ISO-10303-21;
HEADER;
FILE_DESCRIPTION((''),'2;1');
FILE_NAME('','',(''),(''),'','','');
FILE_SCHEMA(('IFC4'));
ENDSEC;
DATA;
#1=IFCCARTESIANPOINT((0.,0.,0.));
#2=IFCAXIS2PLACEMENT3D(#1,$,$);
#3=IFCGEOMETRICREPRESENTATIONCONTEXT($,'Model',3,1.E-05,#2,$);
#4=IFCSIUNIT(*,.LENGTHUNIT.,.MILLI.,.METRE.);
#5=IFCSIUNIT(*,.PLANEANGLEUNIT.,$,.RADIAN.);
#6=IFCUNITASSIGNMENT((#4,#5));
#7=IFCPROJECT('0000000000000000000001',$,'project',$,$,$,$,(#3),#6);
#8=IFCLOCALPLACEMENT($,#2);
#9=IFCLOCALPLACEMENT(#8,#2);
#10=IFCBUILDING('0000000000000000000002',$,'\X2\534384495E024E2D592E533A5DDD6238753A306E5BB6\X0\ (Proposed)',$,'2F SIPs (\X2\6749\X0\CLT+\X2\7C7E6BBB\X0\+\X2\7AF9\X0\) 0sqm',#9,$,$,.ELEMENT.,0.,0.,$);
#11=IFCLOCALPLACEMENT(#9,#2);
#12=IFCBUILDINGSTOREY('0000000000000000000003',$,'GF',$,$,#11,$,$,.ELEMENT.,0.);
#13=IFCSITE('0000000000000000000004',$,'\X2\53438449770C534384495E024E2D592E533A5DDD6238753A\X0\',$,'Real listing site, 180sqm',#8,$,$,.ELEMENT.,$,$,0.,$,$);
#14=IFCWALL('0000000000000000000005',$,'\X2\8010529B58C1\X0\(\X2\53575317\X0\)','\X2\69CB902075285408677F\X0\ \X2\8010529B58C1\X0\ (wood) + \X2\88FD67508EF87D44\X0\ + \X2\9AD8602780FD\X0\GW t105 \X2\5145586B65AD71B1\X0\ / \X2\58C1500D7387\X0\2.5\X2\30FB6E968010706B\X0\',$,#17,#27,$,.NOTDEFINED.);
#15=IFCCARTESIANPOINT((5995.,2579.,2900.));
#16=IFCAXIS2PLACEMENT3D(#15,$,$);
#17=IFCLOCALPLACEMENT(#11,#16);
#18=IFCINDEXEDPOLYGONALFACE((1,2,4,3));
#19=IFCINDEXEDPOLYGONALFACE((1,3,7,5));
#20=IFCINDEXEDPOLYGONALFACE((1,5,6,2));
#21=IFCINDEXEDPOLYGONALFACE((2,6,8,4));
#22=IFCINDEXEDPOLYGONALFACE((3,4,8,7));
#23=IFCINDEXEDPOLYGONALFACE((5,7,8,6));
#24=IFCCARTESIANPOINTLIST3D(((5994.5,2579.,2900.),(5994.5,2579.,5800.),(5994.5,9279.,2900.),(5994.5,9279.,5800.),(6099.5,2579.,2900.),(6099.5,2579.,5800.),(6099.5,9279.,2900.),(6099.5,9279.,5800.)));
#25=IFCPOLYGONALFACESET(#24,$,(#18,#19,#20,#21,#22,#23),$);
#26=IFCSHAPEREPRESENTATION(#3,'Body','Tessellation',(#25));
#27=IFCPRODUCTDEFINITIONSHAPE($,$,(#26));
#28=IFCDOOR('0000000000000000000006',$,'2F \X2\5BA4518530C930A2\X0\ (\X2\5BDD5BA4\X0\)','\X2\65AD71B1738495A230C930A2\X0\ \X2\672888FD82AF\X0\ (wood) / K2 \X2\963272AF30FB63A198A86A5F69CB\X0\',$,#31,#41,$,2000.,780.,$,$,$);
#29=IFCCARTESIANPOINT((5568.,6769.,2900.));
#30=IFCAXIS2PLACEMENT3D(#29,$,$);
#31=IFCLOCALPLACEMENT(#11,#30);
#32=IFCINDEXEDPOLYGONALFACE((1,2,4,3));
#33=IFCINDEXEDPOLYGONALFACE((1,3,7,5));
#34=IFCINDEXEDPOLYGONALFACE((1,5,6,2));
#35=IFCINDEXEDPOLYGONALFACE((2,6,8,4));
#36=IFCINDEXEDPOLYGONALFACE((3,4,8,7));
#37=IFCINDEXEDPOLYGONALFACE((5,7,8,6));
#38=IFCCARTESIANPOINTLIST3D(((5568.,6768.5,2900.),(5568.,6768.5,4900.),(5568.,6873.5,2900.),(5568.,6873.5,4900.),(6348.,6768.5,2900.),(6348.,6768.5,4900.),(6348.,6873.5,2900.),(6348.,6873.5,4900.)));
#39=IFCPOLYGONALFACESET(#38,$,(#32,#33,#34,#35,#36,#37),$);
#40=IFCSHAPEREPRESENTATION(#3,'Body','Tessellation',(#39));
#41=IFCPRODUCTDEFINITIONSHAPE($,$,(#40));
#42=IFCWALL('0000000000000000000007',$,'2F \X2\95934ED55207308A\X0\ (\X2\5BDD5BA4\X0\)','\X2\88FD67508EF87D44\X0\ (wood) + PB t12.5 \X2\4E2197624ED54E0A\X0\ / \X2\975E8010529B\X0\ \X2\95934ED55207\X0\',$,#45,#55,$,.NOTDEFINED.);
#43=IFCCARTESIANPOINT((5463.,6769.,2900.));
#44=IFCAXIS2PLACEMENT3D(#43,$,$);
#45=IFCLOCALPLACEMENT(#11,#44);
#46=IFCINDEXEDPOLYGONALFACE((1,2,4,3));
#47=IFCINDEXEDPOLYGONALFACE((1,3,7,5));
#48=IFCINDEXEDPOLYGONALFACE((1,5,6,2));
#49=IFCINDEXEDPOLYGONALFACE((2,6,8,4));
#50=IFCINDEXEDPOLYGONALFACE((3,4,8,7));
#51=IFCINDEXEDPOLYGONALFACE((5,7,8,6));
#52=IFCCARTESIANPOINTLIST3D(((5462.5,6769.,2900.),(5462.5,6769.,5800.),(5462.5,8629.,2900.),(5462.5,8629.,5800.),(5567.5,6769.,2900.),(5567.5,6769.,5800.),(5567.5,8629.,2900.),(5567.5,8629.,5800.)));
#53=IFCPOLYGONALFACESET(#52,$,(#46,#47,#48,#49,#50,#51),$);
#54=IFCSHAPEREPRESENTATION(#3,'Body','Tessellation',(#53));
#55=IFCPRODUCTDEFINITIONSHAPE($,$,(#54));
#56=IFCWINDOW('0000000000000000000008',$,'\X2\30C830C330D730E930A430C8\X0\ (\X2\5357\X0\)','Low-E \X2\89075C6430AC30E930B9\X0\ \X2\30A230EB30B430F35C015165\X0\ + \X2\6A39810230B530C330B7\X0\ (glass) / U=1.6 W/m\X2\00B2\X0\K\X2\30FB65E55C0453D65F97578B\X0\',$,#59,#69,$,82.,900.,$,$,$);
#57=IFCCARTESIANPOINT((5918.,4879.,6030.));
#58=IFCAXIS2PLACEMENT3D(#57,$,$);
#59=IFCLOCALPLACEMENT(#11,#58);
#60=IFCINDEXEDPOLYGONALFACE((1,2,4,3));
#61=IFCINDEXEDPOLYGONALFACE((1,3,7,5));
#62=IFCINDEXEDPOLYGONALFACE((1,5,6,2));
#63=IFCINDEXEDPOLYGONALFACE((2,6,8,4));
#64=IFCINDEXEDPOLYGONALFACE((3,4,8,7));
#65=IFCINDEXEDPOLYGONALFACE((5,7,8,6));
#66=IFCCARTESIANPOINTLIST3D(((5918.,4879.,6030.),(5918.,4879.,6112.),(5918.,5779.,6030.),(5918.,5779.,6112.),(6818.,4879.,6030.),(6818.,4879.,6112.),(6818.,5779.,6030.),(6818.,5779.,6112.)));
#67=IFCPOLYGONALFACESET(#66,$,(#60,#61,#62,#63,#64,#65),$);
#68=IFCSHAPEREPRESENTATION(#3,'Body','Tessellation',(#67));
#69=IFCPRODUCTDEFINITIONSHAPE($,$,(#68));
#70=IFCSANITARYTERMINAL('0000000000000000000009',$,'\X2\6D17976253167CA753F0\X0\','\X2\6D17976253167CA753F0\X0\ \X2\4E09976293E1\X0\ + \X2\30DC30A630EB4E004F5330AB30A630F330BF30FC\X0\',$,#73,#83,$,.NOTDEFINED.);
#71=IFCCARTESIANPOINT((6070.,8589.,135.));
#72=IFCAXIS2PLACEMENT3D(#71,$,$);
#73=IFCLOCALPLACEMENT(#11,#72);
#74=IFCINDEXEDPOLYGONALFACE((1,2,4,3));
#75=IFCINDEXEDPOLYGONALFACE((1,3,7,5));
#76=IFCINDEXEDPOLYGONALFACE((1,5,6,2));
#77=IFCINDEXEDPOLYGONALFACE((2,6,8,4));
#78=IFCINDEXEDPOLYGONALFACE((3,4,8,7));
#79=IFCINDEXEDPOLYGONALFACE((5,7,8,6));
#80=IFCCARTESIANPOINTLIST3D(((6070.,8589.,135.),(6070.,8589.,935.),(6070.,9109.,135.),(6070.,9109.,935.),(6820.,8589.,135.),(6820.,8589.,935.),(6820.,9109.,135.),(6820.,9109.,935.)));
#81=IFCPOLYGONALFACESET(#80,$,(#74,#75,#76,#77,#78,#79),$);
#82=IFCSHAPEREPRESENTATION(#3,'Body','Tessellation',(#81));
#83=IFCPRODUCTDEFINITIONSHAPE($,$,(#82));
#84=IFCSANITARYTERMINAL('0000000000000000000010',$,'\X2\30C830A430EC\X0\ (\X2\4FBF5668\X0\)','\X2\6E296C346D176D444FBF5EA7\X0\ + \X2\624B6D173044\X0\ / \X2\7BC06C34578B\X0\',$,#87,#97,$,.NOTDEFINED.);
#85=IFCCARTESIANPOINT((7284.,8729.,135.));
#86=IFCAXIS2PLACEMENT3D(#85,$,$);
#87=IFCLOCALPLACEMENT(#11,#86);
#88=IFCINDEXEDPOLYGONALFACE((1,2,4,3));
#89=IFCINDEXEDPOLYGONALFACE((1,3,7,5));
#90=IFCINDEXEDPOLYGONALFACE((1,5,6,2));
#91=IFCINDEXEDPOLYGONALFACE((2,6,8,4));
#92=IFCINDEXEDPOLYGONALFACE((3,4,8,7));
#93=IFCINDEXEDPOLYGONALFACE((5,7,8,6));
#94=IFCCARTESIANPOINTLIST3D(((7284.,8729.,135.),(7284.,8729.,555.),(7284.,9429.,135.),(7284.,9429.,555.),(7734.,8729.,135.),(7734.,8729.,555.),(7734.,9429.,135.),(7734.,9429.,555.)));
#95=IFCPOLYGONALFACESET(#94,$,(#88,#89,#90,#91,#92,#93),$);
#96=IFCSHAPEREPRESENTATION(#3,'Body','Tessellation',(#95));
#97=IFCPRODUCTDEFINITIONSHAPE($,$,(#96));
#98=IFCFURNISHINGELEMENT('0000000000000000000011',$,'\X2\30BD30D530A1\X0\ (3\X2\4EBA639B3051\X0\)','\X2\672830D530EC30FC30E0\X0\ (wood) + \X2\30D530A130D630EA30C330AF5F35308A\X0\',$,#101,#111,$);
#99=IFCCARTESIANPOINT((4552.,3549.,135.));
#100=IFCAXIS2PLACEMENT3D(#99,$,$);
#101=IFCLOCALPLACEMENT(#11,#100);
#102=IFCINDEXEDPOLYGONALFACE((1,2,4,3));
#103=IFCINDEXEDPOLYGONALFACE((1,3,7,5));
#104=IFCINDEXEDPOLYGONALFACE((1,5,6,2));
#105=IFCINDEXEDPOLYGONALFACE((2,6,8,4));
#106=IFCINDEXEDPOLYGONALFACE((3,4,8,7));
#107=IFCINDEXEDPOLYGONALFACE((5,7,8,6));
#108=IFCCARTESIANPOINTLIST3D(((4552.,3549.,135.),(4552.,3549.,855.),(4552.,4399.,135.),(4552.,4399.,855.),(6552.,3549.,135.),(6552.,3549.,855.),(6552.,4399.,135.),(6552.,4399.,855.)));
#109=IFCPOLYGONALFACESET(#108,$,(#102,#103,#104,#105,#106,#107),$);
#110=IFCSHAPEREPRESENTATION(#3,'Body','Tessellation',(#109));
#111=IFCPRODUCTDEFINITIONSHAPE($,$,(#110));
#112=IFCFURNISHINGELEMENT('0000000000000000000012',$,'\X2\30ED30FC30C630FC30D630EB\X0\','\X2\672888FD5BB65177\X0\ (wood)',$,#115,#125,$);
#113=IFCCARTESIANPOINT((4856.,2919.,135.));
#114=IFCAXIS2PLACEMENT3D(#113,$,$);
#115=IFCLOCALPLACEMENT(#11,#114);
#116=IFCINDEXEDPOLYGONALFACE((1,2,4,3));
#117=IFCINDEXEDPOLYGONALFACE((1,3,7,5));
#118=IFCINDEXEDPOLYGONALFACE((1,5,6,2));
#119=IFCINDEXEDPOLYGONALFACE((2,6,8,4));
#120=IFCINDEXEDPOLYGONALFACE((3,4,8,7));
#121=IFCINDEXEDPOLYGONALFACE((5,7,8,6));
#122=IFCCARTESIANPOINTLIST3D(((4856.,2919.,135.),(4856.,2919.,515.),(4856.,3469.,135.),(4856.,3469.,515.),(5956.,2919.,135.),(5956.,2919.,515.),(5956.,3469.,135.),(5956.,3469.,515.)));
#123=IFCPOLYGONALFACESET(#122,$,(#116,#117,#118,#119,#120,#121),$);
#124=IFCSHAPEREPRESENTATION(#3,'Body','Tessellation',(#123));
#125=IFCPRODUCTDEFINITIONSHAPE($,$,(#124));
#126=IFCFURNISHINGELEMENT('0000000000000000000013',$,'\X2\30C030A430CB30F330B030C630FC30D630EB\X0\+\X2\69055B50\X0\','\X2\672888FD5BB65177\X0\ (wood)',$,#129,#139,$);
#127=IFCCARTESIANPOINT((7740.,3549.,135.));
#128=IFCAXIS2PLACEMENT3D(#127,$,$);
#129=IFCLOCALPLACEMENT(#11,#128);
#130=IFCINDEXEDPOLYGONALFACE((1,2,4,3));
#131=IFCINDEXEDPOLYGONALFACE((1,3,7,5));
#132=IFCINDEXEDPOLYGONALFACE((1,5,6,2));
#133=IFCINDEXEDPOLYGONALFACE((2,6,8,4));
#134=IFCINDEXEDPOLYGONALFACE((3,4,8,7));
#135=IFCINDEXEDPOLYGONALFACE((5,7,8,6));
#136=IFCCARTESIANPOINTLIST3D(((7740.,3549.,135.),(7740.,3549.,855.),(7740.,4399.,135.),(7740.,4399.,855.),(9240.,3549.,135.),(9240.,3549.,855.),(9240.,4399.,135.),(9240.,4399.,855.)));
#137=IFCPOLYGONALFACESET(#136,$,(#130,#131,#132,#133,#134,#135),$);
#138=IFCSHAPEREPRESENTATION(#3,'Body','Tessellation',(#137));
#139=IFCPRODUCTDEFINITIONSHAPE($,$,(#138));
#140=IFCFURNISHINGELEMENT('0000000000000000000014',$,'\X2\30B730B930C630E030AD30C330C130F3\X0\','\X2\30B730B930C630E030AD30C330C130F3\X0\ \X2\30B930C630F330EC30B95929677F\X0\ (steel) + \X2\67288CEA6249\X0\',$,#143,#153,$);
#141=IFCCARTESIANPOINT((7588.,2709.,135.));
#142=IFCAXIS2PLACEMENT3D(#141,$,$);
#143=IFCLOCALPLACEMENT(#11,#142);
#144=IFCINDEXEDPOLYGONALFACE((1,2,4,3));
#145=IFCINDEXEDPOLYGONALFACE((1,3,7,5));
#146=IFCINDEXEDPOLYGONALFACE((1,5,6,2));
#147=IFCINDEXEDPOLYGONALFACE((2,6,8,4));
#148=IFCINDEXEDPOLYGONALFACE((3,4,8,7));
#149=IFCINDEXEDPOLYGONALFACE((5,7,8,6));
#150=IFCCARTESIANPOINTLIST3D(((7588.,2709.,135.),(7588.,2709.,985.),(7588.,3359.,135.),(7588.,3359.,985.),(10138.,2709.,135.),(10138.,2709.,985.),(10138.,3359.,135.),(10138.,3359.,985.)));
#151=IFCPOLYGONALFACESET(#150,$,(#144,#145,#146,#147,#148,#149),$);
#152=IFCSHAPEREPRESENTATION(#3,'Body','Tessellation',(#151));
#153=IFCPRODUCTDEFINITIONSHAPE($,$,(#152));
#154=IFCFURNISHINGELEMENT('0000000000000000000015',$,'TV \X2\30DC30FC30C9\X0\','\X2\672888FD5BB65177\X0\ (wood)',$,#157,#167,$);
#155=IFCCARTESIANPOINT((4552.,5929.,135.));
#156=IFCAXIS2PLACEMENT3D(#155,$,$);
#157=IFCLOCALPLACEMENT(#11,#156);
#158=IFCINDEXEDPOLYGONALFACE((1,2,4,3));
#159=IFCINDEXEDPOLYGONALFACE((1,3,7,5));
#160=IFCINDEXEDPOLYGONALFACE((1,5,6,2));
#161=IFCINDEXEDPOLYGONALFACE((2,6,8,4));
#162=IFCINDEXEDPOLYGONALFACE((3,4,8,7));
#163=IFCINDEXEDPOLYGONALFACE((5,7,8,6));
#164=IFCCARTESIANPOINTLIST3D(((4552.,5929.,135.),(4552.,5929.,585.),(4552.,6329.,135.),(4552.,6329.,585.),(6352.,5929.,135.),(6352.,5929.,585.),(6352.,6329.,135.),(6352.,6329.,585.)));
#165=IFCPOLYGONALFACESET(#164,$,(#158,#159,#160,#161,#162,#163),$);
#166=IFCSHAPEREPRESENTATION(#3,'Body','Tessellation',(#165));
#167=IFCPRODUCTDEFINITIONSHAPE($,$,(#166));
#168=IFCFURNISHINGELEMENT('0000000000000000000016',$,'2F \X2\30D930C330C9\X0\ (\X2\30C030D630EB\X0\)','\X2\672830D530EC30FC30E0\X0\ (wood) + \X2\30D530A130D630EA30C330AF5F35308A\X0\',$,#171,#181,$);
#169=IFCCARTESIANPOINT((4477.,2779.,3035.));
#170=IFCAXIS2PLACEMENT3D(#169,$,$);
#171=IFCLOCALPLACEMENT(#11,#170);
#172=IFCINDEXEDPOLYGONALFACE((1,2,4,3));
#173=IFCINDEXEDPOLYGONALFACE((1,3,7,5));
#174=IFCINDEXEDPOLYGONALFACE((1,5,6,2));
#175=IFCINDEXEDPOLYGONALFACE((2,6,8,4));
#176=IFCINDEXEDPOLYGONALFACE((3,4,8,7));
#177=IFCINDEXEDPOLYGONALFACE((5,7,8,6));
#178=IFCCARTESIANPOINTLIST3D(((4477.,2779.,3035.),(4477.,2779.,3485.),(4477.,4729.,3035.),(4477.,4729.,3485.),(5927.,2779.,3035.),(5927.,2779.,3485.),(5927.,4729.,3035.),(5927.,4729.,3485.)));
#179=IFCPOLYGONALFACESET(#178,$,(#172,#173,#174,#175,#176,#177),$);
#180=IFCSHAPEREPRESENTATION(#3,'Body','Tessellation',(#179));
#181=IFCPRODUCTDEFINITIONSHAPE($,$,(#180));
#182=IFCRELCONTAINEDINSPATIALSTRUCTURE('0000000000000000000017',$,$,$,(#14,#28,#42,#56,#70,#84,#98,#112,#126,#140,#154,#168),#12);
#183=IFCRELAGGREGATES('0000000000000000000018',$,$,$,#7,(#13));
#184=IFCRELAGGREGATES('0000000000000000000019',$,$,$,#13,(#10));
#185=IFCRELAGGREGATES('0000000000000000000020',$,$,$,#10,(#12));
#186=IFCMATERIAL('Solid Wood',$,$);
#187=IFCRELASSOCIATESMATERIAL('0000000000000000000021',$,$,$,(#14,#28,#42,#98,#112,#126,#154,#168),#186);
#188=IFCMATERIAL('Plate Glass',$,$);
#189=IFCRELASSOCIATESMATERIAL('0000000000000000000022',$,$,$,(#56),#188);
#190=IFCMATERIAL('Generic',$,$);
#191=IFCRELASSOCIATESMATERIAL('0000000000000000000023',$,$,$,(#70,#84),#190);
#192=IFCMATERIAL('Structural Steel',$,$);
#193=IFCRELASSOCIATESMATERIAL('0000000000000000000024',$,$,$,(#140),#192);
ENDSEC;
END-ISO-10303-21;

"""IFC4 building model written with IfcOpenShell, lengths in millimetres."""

from ifc_helpers import new_model, si_unit, frame, frame_2d, origin, place, context, project, spatial, rectangle, extrude, material, element, fill, save


model = new_model("IFC4")

# Units and contexts
model_context = context("Model", 3, precision=1e-05, world=origin())
ifc_project = project(units=[si_unit("LENGTHUNIT", "METRE", prefix="MILLI"), si_unit("PLANEANGLEUNIT", "RADIAN")], contexts=[model_context])

# Site, building, storey
site_placement = place(None, origin())
site = spatial("IfcSite", under=ifc_project, at=site_placement, Name="千葉県千葉市中央区川戸町", ObjectType="Real listing site, 180sqm", CompositionType="ELEMENT", RefElevation=0.0)
building_placement = place(site_placement, origin())
building = spatial("IfcBuilding", under=site, at=building_placement, Name="千葉市中央区川戸町の家 (Proposed)", ObjectType="2F SIPs (杉CLT+籾殻+竹) 0sqm", CompositionType="ELEMENT", ElevationOfRefHeight=0.0, ElevationOfTerrain=0.0)
storey_placement = place(building_placement, origin())
storey = spatial("IfcBuildingStorey", under=building, at=storey_placement, Name="GF", CompositionType="ELEMENT", Elevation=0.0)

# Shared definitions
ifc_material_1 = material(Name="Solid Wood")

# Wall, opening, door
wall_1_placement = place(storey_placement, frame((5995.0, 2579.0, 2900.0)))
wall_1 = element("IfcWall", 1, at=wall_1_placement, inside=storey, material=ifc_material_1, Name="耐力壁(南北)", Description="構造用合板 耐力壁 (wood) + 製材軸組 + 高性能GW t105 充填断熱 / 壁倍率2.5・準耐火", PredefinedType="NOTDEFINED", context=model_context, shape_type="SweptSolid", body=[
    extrude(rectangle(XDim=105.0, YDim=6700.0, at=frame_2d((52.0, 3350.0))), frame((5995.0, 2579.0, 2900.0)), (0.0, 0.0, 1.0), 2900.0),
])
opening_1_placement = place(storey_placement, frame((5568.0, 6769.0, 2900.0)))
opening_1 = element("IfcOpeningElement", 2, at=opening_1_placement, cuts=wall_1, PredefinedType="NOTDEFINED", context=model_context, shape_type="SweptSolid", body=[
    extrude(rectangle(XDim=780.0, YDim=105.0, at=frame_2d((390.0, 52.0))), frame((5568.0, 6769.0, 2900.0)), (0.0, 0.0, 1.0), 2000.0),
])
door_1_placement = place(storey_placement, frame((5568.0, 6769.0, 2900.0)))
door_1 = element("IfcDoor", 3, at=door_1_placement, inside=storey, material=ifc_material_1, Name="2F 室内ドア (寝室)", Description="断熱玄関ドア 木製芯 (wood) / K2 防犯・採風機構", OverallHeight=2000.0, OverallWidth=780.0, context=model_context, shape_type="SweptSolid", body=[
    extrude(rectangle(XDim=780.0, YDim=105.0, at=frame_2d((390.0, 52.0))), frame((5568.0, 6769.0, 2900.0)), (0.0, 0.0, 1.0), 2000.0),
])
fill(opening_1, door_1)

# Wall
wall_2_placement = place(storey_placement, frame((5463.0, 6769.0, 2900.0)))
element("IfcWall", 4, at=wall_2_placement, inside=storey, material=ifc_material_1, Name="2F 間仕切り (寝室)", Description="製材軸組 (wood) + PB t12.5 両面仕上 / 非耐力 間仕切", PredefinedType="NOTDEFINED", context=model_context, shape_type="SweptSolid", body=[
    extrude(rectangle(XDim=105.0, YDim=1860.0, at=frame_2d((52.0, 930.0))), frame((5463.0, 6769.0, 2900.0)), (0.0, 0.0, 1.0), 2900.0),
])

# Window
ifc_material_2 = material(Name="Plate Glass")
window_placement = place(storey_placement, frame((5918.0, 4879.0, 6030.0)))
element("IfcWindow", 5, at=window_placement, inside=storey, material=ifc_material_2, Name="トップライト (南)", Description="Low-E 複層ガラス アルゴン封入 + 樹脂サッシ (glass) / U=1.6 W/m²K・日射取得型", OverallHeight=82.0, OverallWidth=900.0, context=model_context, shape_type="SweptSolid", body=[
    extrude(rectangle(XDim=900.0, YDim=900.0, at=frame_2d((450.0, 450.0))), frame((5918.0, 4879.0, 6030.0)), (0.0, 0.0, 1.0), 82.0),
])

# Sanitary terminals
ifc_material_3 = material(Name="Generic")
sanitary_terminal_1_placement = place(storey_placement, frame((6070.0, 8589.0, 135.0)))
element("IfcSanitaryTerminal", 6, at=sanitary_terminal_1_placement, inside=storey, material=ifc_material_3, Name="洗面化粧台", Description="洗面化粧台 三面鏡 + ボウル一体カウンター", PredefinedType="NOTDEFINED", context=model_context, shape_type="SweptSolid", body=[
    extrude(rectangle(XDim=750.0, YDim=520.0, at=frame_2d((375.0, 260.0))), frame((6070.0, 8589.0, 135.0)), (0.0, 0.0, 1.0), 800.0),
])
sanitary_terminal_2_placement = place(storey_placement, frame((7284.0, 8729.0, 135.0)))
element("IfcSanitaryTerminal", 7, at=sanitary_terminal_2_placement, inside=storey, material=ifc_material_3, Name="トイレ (便器)", Description="温水洗浄便座 + 手洗い / 節水型", PredefinedType="NOTDEFINED", context=model_context, shape_type="SweptSolid", body=[
    extrude(rectangle(XDim=450.0, YDim=700.0, at=frame_2d((225.0, 350.0))), frame((7284.0, 8729.0, 135.0)), (0.0, 0.0, 1.0), 420.0),
])

# Furnishing elements
furnishing_1_placement = place(storey_placement, frame((4552.0, 3549.0, 135.0)))
element("IfcFurnishingElement", 8, at=furnishing_1_placement, inside=storey, material=ifc_material_1, Name="ソファ (3人掛け)", Description="木フレーム (wood) + ファブリック張り", context=model_context, shape_type="SweptSolid", body=[
    extrude(rectangle(XDim=2000.0, YDim=850.0, at=frame_2d((1000.0, 425.0))), frame((4552.0, 3549.0, 135.0)), (0.0, 0.0, 1.0), 720.0),
])
furnishing_2_placement = place(storey_placement, frame((4856.0, 2919.0, 135.0)))
element("IfcFurnishingElement", 9, at=furnishing_2_placement, inside=storey, material=ifc_material_1, Name="ローテーブル", Description="木製家具 (wood)", context=model_context, shape_type="SweptSolid", body=[
    extrude(rectangle(XDim=1100.0, YDim=550.0, at=frame_2d((550.0, 275.0))), frame((4856.0, 2919.0, 135.0)), (0.0, 0.0, 1.0), 380.0),
])
furnishing_3_placement = place(storey_placement, frame((7740.0, 3549.0, 135.0)))
element("IfcFurnishingElement", 10, at=furnishing_3_placement, inside=storey, material=ifc_material_1, Name="ダイニングテーブル+椅子", Description="木製家具 (wood)", context=model_context, shape_type="SweptSolid", body=[
    extrude(rectangle(XDim=1500.0, YDim=850.0, at=frame_2d((750.0, 425.0))), frame((7740.0, 3549.0, 135.0)), (0.0, 0.0, 1.0), 720.0),
])
ifc_material_4 = material(Name="Structural Steel")
furnishing_4_placement = place(storey_placement, frame((7588.0, 2709.0, 135.0)))
element("IfcFurnishingElement", 11, at=furnishing_4_placement, inside=storey, material=ifc_material_4, Name="システムキッチン", Description="システムキッチン ステンレス天板 (steel) + 木質扉", context=model_context, shape_type="SweptSolid", body=[
    extrude(rectangle(XDim=2550.0, YDim=650.0, at=frame_2d((1275.0, 325.0))), frame((7588.0, 2709.0, 135.0)), (0.0, 0.0, 1.0), 850.0),
])
furnishing_5_placement = place(storey_placement, frame((4552.0, 5929.0, 135.0)))
element("IfcFurnishingElement", 12, at=furnishing_5_placement, inside=storey, material=ifc_material_1, Name="TV ボード", Description="木製家具 (wood)", context=model_context, shape_type="SweptSolid", body=[
    extrude(rectangle(XDim=1800.0, YDim=400.0, at=frame_2d((900.0, 200.0))), frame((4552.0, 5929.0, 135.0)), (0.0, 0.0, 1.0), 450.0),
])
furnishing_6_placement = place(storey_placement, frame((4477.0, 2779.0, 3035.0)))
element("IfcFurnishingElement", 13, at=furnishing_6_placement, inside=storey, material=ifc_material_1, Name="2F ベッド (ダブル)", Description="木フレーム (wood) + ファブリック張り", context=model_context, shape_type="SweptSolid", body=[
    extrude(rectangle(XDim=1450.0, YDim=1950.0, at=frame_2d((725.0, 975.0))), frame((4477.0, 2779.0, 3035.0)), (0.0, 0.0, 1.0), 450.0),
])

save(model, "model.ifc")
